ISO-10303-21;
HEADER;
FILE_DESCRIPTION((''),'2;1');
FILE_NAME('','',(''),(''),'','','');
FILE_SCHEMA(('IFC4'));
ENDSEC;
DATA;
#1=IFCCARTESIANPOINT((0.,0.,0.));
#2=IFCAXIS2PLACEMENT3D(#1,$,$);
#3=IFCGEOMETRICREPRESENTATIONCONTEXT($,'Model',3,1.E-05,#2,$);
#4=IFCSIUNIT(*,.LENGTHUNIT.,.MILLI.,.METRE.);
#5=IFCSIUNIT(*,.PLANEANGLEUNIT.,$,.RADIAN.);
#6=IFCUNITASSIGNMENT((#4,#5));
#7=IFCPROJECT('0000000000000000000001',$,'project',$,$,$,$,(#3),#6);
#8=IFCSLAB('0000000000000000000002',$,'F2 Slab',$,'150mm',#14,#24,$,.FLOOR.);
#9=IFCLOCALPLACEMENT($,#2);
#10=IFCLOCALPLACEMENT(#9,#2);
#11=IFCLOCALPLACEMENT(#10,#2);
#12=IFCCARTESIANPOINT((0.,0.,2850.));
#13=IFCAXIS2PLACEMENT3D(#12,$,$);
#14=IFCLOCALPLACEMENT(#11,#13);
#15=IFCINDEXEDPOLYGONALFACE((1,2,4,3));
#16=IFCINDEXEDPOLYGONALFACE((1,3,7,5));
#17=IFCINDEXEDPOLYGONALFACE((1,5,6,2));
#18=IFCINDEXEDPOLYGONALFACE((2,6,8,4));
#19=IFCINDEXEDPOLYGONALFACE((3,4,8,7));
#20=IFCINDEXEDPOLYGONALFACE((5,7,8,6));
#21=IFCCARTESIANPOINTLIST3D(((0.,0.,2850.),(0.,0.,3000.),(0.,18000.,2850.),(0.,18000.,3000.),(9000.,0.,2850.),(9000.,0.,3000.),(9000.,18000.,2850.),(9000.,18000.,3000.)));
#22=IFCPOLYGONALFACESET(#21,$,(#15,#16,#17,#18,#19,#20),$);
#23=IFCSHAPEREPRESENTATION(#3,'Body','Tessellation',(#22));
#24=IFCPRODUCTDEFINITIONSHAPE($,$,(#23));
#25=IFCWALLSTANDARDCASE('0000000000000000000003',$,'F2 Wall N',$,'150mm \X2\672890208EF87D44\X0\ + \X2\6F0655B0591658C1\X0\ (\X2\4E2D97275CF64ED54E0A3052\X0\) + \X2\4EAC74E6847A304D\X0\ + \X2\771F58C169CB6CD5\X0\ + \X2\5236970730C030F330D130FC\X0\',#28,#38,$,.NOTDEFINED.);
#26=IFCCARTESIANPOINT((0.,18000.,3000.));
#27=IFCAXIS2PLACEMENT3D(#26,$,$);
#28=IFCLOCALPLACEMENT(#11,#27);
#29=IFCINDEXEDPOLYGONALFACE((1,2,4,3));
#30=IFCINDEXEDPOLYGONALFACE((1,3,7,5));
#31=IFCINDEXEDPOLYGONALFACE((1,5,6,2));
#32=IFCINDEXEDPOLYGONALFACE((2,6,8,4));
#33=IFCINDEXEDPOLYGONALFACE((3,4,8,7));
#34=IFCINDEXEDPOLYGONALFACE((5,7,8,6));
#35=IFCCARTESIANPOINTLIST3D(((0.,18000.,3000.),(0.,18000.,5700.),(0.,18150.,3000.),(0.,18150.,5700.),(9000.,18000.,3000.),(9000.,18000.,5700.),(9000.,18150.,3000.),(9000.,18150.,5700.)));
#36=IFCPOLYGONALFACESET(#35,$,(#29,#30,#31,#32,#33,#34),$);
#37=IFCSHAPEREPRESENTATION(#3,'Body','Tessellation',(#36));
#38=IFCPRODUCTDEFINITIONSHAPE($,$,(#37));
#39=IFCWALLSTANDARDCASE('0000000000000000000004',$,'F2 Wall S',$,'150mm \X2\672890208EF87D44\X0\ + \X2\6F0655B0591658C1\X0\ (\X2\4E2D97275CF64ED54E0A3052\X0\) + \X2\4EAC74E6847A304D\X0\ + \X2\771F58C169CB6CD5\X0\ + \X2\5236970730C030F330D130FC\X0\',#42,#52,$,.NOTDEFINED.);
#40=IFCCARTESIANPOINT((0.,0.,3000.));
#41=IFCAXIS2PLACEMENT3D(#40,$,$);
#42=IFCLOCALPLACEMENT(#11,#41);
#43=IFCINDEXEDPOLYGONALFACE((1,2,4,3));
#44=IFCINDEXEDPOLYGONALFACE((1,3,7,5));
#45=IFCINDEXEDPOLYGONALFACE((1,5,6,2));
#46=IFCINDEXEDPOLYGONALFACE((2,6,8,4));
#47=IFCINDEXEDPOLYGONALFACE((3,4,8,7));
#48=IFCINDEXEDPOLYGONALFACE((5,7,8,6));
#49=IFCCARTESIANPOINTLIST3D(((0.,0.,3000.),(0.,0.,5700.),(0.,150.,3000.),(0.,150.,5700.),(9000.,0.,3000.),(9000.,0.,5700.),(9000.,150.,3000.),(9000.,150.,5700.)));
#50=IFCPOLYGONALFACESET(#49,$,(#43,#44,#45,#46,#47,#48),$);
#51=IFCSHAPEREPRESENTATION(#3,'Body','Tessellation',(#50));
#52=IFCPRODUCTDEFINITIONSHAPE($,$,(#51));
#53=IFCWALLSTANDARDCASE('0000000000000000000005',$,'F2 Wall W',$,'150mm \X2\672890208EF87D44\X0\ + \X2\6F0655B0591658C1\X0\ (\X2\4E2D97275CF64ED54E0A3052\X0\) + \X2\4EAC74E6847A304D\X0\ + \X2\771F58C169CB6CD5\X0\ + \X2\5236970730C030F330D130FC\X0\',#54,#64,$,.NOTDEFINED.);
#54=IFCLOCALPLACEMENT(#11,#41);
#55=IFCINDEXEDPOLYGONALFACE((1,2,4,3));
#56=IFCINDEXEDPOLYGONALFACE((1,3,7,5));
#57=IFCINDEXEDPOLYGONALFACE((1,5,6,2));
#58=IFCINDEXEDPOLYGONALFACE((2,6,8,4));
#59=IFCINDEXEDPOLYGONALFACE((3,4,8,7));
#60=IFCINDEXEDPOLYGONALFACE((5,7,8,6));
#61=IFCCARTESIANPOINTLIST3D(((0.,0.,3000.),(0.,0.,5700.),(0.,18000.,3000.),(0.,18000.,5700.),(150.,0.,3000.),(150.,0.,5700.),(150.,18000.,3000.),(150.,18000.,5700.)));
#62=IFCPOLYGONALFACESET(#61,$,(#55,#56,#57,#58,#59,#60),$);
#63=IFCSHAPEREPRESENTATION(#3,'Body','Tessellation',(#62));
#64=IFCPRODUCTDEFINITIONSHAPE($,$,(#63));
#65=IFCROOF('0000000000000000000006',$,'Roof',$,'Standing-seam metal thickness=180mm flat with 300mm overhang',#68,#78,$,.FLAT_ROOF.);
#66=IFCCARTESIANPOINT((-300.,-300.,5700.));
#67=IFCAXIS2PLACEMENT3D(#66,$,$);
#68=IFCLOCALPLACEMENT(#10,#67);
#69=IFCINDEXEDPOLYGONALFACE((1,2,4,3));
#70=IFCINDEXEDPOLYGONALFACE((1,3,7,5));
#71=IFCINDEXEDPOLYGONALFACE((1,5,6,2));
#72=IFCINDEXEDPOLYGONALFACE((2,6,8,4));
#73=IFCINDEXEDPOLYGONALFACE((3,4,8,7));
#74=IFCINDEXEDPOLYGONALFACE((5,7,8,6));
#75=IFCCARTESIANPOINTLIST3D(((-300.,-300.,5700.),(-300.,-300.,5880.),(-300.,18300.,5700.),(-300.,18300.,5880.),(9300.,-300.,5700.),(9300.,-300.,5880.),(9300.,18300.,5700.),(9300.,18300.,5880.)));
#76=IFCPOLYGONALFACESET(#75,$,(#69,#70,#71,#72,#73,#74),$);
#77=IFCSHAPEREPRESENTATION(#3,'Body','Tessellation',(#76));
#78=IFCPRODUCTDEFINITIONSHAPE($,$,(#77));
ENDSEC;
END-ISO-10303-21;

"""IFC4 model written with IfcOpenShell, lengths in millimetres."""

from ifc_helpers import new_model, si_unit, frame, frame_2d, origin, place, context, project, rectangle, extrude, element, save


model = new_model("IFC4")

# Units and contexts
model_context = context("Model", 3, precision=1e-05, world=origin())
ifc_project = project(units=[si_unit("LENGTHUNIT", "METRE", prefix="MILLI"), si_unit("PLANEANGLEUNIT", "RADIAN")], contexts=[model_context])

# Slab
placement_1 = place(None, origin())
placement_2 = place(placement_1, origin())
placement_3 = place(placement_2, origin())
slab_placement = place(placement_3, frame((0.0, 0.0, 2850.0)))
element("IfcSlab", 1, at=slab_placement, Name="F2 Slab", ObjectType="150mm", PredefinedType="FLOOR", context=model_context, shape_type="SweptSolid", body=[
    extrude(rectangle(XDim=9000.0, YDim=18000.0, at=frame_2d((4500.0, 9000.0))), frame((0.0, 0.0, 2850.0)), (0.0, 0.0, 1.0), 150.0),
])

# Walls
wall_1_placement = place(placement_3, frame((0.0, 18000.0, 3000.0)))
element("IfcWallStandardCase", 2, at=wall_1_placement, Name="F2 Wall N", ObjectType="150mm 木造軸組 + 漆喰外壁 (中霧島仕上げ) + 京瓦葺き + 真壁構法 + 制震ダンパー", PredefinedType="NOTDEFINED", context=model_context, shape_type="SweptSolid", body=[
    extrude(rectangle(XDim=9000.0, YDim=150.0, at=frame_2d((4500.0, 75.0))), frame((0.0, 18000.0, 3000.0)), (0.0, 0.0, 1.0), 2700.0),
])
wall_2_placement = place(placement_3, frame((0.0, 0.0, 3000.0)))
element("IfcWallStandardCase", 3, at=wall_2_placement, Name="F2 Wall S", ObjectType="150mm 木造軸組 + 漆喰外壁 (中霧島仕上げ) + 京瓦葺き + 真壁構法 + 制震ダンパー", PredefinedType="NOTDEFINED", context=model_context, shape_type="SweptSolid", body=[
    extrude(rectangle(XDim=9000.0, YDim=150.0, at=frame_2d((4500.0, 75.0))), frame((0.0, 0.0, 3000.0)), (0.0, 0.0, 1.0), 2700.0),
])
wall_3_placement = place(placement_3, frame((0.0, 0.0, 3000.0)))
element("IfcWallStandardCase", 4, at=wall_3_placement, Name="F2 Wall W", ObjectType="150mm 木造軸組 + 漆喰外壁 (中霧島仕上げ) + 京瓦葺き + 真壁構法 + 制震ダンパー", PredefinedType="NOTDEFINED", context=model_context, shape_type="SweptSolid", body=[
    extrude(rectangle(XDim=150.0, YDim=18000.0, at=frame_2d((75.0, 9000.0))), frame((0.0, 0.0, 3000.0)), (0.0, 0.0, 1.0), 2700.0),
])

# Roof
roof_placement = place(placement_2, frame((-300.0, -300.0, 5700.0)))
element("IfcRoof", 5, at=roof_placement, Name="Roof", ObjectType="Standing-seam metal thickness=180mm flat with 300mm overhang", PredefinedType="FLAT_ROOF", context=model_context, shape_type="SweptSolid", body=[
    extrude(rectangle(XDim=9600.0, YDim=18600.0, at=frame_2d((4800.0, 9300.0))), frame((-300.0, -300.0, 5700.0)), (0.0, 0.0, 1.0), 180.0),
])

save(model, "model.ifc")
